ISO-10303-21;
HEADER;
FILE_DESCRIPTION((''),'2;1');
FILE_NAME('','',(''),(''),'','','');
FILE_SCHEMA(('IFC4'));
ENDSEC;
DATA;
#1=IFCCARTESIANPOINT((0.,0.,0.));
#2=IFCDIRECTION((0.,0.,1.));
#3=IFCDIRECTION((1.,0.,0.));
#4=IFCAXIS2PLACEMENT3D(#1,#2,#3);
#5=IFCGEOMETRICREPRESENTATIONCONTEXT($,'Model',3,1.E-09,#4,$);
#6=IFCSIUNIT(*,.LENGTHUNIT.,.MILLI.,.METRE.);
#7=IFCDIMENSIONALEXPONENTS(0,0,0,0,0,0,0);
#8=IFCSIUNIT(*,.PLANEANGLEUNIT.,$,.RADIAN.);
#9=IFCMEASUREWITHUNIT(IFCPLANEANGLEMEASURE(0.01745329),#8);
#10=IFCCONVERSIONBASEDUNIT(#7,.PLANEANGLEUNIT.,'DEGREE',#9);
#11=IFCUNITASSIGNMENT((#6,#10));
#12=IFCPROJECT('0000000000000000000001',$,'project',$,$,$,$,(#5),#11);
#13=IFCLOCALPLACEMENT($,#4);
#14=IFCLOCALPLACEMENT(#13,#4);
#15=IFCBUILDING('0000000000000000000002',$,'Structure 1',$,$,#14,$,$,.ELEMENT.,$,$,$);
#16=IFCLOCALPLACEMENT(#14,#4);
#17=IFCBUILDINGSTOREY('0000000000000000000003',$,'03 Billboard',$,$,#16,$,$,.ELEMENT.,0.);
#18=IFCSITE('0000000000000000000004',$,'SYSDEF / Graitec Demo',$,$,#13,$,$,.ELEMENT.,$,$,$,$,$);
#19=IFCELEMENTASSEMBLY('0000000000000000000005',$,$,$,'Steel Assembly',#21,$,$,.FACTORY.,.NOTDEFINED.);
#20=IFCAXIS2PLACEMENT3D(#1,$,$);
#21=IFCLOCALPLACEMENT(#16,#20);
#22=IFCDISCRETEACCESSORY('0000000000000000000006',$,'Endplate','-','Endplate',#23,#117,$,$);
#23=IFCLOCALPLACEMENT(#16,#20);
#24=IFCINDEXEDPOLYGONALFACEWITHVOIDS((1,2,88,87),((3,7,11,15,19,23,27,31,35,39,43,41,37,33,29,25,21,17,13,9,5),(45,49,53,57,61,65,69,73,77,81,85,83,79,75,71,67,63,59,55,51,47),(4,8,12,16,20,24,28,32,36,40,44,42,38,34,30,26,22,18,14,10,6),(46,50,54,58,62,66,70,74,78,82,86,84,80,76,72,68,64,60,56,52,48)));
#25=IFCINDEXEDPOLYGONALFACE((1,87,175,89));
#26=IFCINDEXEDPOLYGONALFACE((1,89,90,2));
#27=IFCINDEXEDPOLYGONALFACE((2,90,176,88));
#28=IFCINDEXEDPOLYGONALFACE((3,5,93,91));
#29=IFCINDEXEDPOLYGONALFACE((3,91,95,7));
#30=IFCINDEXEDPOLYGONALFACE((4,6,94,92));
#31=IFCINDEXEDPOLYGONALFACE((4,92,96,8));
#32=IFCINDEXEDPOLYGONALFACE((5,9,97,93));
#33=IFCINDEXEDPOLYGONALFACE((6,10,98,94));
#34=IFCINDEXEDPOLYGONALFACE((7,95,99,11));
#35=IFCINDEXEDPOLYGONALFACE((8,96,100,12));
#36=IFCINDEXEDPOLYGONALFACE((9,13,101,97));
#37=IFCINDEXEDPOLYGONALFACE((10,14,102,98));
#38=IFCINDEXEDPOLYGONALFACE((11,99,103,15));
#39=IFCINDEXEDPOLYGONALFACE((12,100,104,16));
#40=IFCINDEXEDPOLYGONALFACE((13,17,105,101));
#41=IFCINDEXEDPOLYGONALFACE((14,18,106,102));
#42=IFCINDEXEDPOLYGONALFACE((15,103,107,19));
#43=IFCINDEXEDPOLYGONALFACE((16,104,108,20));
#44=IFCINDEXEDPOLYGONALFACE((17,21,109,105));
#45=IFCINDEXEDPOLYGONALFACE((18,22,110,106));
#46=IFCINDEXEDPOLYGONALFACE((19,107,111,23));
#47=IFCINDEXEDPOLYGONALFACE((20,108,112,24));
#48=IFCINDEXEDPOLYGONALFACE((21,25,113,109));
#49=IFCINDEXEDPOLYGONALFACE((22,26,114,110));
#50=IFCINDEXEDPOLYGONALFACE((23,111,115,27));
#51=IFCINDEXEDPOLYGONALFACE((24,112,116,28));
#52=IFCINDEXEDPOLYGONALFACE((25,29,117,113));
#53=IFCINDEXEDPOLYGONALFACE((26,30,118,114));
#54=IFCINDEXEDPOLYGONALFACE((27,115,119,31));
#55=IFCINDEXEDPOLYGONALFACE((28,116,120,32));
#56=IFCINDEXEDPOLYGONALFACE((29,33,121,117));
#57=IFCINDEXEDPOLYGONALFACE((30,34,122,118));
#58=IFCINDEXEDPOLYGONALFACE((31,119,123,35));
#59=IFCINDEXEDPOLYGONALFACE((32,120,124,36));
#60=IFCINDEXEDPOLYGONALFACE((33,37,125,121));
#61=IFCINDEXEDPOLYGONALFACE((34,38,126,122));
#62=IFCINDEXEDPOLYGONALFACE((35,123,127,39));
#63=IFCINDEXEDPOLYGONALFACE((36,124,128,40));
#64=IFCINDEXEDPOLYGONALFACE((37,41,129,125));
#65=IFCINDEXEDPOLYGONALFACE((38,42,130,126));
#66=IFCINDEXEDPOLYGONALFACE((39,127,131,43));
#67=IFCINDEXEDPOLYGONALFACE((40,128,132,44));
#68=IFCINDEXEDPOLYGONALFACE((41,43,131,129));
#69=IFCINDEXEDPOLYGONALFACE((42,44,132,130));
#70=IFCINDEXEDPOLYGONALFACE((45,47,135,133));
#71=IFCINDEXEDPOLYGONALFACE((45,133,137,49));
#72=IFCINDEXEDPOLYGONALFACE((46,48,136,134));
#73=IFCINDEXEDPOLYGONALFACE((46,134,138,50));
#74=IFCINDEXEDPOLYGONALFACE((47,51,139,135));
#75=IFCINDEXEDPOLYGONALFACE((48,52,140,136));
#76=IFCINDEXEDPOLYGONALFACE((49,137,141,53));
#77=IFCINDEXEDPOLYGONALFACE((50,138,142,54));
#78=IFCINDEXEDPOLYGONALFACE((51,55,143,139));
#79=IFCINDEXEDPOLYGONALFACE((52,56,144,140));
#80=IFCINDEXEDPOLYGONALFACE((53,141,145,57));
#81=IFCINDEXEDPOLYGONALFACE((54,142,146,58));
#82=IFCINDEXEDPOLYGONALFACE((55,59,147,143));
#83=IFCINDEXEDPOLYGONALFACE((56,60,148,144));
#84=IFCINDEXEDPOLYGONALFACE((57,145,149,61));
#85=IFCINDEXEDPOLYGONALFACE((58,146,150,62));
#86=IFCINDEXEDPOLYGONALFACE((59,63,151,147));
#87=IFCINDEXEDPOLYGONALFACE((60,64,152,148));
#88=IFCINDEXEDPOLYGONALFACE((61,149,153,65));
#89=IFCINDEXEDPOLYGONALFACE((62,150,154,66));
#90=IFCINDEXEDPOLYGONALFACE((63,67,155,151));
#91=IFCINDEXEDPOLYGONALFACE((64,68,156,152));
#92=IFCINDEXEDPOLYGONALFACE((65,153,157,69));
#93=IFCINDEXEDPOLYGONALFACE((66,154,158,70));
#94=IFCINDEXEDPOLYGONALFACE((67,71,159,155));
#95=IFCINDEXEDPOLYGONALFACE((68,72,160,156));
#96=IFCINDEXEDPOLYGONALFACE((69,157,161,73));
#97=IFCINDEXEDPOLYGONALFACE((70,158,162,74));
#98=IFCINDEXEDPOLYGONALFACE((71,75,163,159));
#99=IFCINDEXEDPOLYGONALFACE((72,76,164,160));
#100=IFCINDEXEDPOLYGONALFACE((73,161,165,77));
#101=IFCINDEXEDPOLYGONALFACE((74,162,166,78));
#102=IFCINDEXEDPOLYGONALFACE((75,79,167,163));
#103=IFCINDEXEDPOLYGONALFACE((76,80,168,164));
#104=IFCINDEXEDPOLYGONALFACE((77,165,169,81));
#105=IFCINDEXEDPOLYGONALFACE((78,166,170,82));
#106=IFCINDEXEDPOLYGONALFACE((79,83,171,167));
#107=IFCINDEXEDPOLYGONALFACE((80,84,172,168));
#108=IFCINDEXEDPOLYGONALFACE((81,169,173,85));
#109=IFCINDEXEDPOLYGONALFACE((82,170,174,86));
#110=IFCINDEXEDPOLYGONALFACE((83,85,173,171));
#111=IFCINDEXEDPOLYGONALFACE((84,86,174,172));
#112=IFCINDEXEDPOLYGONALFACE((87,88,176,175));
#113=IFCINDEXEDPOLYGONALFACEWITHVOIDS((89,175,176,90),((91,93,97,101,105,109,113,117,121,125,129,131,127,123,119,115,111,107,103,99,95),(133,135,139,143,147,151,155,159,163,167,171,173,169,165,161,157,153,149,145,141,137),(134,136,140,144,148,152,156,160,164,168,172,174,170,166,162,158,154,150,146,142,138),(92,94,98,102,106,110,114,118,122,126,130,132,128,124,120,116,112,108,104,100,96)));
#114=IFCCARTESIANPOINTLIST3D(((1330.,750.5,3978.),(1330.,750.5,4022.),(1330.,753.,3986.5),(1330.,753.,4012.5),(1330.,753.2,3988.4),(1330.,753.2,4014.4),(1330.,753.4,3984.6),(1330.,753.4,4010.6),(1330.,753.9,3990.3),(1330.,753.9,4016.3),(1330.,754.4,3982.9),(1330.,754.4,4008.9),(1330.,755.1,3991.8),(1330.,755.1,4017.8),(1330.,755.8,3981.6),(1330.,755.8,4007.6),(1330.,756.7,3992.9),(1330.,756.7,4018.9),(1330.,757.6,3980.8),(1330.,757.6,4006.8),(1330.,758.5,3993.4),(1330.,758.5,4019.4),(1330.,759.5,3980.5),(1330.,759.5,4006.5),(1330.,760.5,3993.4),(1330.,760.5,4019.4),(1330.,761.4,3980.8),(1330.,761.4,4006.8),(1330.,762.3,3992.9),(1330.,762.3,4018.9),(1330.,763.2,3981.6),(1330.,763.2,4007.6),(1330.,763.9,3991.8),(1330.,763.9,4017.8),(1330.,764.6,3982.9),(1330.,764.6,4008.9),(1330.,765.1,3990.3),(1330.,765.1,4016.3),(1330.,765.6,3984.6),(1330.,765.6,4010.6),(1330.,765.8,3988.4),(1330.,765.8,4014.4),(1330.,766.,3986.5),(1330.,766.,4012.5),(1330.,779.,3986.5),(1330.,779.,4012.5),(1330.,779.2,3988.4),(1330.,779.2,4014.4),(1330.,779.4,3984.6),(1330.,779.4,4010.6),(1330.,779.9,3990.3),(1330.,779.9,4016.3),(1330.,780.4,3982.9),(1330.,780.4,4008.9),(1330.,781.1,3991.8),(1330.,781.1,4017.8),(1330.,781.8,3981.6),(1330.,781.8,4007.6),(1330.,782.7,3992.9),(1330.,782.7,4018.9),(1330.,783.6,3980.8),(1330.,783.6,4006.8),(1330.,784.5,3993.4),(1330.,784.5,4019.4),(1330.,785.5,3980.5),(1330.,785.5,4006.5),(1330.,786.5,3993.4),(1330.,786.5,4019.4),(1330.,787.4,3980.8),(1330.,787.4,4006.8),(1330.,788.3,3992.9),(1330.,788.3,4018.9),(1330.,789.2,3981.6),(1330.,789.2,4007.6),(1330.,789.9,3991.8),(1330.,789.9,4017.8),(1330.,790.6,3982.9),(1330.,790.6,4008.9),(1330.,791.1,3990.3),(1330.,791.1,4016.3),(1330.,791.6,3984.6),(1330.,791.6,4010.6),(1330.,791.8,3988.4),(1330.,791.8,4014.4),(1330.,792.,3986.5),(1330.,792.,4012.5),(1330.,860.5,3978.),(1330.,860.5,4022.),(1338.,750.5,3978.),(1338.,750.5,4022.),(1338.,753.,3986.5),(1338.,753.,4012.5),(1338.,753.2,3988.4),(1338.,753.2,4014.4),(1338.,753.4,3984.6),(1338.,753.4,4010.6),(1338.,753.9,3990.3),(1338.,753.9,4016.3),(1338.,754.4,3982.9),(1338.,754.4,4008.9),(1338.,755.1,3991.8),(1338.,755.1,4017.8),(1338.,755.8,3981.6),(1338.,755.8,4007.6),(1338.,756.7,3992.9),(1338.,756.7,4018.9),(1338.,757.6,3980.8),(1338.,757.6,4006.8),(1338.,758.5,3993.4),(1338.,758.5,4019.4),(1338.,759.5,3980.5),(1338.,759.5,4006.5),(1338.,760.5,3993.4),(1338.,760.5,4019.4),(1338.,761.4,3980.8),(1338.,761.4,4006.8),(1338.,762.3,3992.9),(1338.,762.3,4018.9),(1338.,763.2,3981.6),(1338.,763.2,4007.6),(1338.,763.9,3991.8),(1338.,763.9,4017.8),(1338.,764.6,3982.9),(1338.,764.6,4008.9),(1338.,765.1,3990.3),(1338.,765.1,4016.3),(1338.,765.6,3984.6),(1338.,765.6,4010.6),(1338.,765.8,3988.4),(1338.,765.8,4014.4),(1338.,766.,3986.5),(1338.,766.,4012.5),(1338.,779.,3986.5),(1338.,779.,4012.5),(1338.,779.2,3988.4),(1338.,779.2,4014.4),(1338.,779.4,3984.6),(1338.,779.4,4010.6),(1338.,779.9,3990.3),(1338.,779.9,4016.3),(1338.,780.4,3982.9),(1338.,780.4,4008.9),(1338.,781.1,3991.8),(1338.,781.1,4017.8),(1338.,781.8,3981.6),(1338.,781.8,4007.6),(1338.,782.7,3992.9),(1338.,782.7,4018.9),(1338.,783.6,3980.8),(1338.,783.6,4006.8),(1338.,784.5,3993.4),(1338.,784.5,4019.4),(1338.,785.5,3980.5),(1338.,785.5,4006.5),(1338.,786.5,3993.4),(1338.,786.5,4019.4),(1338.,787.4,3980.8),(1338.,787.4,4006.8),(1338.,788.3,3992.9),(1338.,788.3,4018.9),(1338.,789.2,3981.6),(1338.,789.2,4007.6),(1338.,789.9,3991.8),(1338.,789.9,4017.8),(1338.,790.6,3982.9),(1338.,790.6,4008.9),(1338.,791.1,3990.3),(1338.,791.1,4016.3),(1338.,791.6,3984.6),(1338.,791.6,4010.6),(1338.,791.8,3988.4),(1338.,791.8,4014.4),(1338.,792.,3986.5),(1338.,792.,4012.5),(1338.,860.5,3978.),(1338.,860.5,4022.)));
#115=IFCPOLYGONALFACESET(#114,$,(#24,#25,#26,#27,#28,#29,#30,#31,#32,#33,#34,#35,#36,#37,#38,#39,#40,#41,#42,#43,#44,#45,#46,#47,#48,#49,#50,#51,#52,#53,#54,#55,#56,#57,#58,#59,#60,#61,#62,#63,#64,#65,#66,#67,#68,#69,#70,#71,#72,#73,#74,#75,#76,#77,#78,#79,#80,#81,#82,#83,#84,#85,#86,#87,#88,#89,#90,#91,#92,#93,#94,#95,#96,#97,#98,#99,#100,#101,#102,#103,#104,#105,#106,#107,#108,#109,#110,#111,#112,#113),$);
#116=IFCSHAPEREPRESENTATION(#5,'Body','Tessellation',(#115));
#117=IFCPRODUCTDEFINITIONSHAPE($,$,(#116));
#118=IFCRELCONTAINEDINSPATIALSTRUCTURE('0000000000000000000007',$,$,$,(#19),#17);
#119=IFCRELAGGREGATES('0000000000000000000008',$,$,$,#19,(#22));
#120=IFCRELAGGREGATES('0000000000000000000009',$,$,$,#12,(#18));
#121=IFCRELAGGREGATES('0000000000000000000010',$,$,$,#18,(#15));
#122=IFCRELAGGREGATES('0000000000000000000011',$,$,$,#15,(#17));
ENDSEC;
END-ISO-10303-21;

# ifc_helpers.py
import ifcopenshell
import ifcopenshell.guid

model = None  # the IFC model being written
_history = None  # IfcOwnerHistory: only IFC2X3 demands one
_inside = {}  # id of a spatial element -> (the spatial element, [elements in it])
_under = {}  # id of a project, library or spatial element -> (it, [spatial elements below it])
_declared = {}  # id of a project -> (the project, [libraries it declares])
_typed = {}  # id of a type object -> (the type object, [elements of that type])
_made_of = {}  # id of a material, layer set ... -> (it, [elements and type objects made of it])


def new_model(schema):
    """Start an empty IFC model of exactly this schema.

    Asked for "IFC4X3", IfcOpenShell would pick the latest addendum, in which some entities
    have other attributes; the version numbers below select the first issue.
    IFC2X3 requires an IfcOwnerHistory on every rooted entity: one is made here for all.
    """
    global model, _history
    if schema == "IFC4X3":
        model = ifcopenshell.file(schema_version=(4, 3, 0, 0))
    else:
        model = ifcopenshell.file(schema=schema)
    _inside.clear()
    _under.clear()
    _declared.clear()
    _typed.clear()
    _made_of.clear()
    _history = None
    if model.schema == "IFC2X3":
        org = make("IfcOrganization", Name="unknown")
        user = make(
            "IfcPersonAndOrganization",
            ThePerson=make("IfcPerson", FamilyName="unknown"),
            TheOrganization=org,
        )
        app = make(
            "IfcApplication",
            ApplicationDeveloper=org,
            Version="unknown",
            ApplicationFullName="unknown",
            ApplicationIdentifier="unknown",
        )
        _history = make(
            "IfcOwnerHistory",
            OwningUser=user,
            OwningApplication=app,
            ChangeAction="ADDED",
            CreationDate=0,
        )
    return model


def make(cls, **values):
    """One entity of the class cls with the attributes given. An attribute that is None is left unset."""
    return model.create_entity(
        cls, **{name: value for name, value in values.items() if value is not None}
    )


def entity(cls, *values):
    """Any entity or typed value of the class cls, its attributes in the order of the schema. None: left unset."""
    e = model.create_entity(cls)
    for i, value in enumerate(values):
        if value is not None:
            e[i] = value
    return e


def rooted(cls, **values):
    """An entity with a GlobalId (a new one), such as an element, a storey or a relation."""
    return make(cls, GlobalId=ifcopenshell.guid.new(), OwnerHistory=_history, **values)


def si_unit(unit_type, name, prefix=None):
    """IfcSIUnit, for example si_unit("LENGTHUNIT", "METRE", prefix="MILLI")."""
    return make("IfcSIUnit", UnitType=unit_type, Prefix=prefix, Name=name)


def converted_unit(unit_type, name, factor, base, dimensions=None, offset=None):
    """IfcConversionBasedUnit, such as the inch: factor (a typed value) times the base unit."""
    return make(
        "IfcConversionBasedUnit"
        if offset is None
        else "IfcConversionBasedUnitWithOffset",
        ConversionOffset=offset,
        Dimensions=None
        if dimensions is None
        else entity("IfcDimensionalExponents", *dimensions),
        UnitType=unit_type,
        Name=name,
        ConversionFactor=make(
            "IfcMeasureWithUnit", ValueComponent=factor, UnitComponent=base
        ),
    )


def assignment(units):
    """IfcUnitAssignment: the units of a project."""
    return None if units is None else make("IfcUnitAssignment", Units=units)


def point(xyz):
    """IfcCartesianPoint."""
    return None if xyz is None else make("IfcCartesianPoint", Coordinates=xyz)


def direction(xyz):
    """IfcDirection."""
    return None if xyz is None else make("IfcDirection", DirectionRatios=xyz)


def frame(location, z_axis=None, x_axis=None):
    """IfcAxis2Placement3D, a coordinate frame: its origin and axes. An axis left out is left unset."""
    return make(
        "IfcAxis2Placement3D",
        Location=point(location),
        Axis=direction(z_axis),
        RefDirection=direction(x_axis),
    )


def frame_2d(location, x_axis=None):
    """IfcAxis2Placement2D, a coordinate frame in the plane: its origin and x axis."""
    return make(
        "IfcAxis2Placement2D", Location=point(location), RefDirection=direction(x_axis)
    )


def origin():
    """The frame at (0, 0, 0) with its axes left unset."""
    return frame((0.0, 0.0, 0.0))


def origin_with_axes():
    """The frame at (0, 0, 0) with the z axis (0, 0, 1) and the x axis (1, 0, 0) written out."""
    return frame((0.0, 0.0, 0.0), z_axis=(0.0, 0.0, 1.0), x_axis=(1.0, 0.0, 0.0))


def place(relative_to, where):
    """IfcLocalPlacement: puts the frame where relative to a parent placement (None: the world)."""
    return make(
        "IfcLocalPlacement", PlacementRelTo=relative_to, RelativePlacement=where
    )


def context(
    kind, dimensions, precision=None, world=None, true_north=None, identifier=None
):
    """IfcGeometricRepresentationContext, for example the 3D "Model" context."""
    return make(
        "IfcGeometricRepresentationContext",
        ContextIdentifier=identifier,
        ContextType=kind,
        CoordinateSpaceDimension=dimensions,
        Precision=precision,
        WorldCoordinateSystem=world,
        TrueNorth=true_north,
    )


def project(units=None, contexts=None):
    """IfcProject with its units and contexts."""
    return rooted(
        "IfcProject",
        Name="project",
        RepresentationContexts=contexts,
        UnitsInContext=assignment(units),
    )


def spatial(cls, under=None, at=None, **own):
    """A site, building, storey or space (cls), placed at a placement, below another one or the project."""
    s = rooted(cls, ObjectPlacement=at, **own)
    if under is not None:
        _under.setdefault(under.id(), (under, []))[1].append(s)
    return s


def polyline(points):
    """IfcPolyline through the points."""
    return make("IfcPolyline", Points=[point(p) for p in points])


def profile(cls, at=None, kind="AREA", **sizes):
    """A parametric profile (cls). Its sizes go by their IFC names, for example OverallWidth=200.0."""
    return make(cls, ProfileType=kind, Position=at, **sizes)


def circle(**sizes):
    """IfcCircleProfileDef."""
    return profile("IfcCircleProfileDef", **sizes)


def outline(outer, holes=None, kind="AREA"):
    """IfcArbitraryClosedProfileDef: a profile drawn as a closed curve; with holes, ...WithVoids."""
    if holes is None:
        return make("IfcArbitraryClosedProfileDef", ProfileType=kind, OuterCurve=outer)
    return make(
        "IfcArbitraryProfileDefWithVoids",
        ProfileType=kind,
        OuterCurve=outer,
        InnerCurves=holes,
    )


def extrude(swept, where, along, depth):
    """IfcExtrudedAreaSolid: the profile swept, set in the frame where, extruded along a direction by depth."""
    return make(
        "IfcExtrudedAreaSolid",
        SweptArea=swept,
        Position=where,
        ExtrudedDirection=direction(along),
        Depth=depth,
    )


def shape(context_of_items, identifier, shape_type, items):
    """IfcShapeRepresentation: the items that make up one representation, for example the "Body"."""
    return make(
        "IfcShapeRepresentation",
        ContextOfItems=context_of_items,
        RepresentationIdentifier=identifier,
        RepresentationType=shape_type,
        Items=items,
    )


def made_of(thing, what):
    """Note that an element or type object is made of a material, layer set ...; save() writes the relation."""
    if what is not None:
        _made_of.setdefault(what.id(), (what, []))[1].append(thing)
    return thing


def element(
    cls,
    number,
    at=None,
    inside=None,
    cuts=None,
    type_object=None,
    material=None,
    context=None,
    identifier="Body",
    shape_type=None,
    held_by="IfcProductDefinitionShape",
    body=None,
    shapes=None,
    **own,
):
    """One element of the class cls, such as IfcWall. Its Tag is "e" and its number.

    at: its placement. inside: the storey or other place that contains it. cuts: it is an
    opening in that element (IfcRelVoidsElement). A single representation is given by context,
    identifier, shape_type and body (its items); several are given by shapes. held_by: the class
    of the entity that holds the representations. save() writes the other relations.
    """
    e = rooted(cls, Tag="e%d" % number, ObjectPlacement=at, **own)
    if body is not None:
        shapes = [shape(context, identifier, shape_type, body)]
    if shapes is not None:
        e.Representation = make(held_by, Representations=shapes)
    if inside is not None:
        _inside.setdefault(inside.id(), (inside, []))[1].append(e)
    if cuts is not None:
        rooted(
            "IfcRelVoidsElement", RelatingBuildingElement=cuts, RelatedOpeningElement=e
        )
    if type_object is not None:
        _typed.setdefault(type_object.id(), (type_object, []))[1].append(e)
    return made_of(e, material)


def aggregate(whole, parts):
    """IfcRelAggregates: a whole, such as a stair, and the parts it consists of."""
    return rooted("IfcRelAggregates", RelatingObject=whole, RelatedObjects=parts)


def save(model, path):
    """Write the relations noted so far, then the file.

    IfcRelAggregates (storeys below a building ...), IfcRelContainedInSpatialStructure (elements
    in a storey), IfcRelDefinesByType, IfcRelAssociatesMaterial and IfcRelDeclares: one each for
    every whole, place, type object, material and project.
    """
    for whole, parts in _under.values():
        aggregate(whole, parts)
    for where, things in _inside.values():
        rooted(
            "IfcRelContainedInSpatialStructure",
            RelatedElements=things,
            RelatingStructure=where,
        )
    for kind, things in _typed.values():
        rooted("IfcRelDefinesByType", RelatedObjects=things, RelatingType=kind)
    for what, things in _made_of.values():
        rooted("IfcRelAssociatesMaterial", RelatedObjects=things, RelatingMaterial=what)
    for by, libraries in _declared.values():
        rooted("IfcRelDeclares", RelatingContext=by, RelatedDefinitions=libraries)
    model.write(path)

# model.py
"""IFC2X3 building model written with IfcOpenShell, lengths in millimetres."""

from ifc_helpers import new_model, entity, si_unit, converted_unit, frame, frame_2d, origin, origin_with_axes, place, context, project, spatial, polyline, circle, outline, extrude, element, aggregate, save


model = new_model("IFC2X3")

# Units and contexts
model_context = context("Model", 3, precision=1e-09, world=origin_with_axes())
ifc_project = project(units=[si_unit("LENGTHUNIT", "METRE", prefix="MILLI"), converted_unit("PLANEANGLEUNIT", "DEGREE", entity("IfcPlaneAngleMeasure", 0.01745329), si_unit("PLANEANGLEUNIT", "RADIAN"), dimensions=[0, 0, 0, 0, 0, 0, 0])], contexts=[model_context])

# Site, building, storey
site_placement = place(None, origin_with_axes())
site = spatial("IfcSite", under=ifc_project, at=site_placement, Name="SYSDEF / Graitec Demo", CompositionType="ELEMENT")
building_placement = place(site_placement, origin_with_axes())
building = spatial("IfcBuilding", under=site, at=building_placement, Name="Structure 1", CompositionType="ELEMENT")
storey_placement = place(building_placement, origin_with_axes())
storey = spatial("IfcBuildingStorey", under=building, at=storey_placement, Name="03 Billboard", CompositionType="ELEMENT", Elevation=0.0)

# Element assembly, discrete accessory, openings
assembly_1_placement = place(None, frame((935.5, 1441.4, 4091.5), z_axis=(-1.0, 0.0, 0.0), x_axis=(0.0, -1.0, 0.0)))
assembly_1 = element("IfcElementAssembly", 1, at=assembly_1_placement, inside=storey, ObjectType="Steel Assembly", AssemblyPlace="FACTORY", PredefinedType="NOTDEFINED")
discrete_accessory_1_placement = place(assembly_1_placement, frame((580.9, -69.5, -394.5), z_axis=(0.0, 0.0, -1.0), x_axis=(1.0, 0.0, 0.0)))
discrete_accessory_1 = element("IfcDiscreteAccessory", 2, at=discrete_accessory_1_placement, Name="Endplate", Description="-", ObjectType="Endplate", context=model_context, shape_type="SweptSolid", body=[
    extrude(outline(polyline([(0.0, 0.0), (110.0, 0.0), (110.0, 44.0), (0.0, 44.0), (0.0, 0.0)])), origin_with_axes(), (0.0, 0.0, 1.0), 8.0),
])
opening_1_placement = place(discrete_accessory_1_placement, frame((88.0, 22.0, -0.5), z_axis=(0.0, 0.0, 1.0), x_axis=(0.0, 1.0, 0.0)))
element("IfcOpeningElement", 3, at=opening_1_placement, cuts=discrete_accessory_1, ObjectType="Opening", context=model_context, shape_type="SweptSolid", body=[
    extrude(circle(Radius=6.5, at=frame_2d((13.0, 13.0), x_axis=(1.0, 0.0))), origin(), (0.0, 0.0, 1.0), 9.0),
])
opening_2_placement = place(discrete_accessory_1_placement, frame((88.0, 22.0, -0.5), z_axis=(0.0, 0.0, 1.0), x_axis=(0.0, 1.0, 0.0)))
element("IfcOpeningElement", 4, at=opening_2_placement, cuts=discrete_accessory_1, ObjectType="Opening", context=model_context, shape_type="SweptSolid", body=[
    extrude(circle(Radius=6.5, at=frame_2d((-13.0, 13.0), x_axis=(1.0, 0.0))), origin(), (0.0, 0.0, 1.0), 9.0),
])
opening_3_placement = place(discrete_accessory_1_placement, frame((88.0, 22.0, -0.5), z_axis=(0.0, 0.0, 1.0), x_axis=(0.0, 1.0, 0.0)))
element("IfcOpeningElement", 5, at=opening_3_placement, cuts=discrete_accessory_1, ObjectType="Opening", context=model_context, shape_type="SweptSolid", body=[
    extrude(circle(Radius=6.5, at=frame_2d((13.0, -13.0), x_axis=(1.0, 0.0))), origin(), (0.0, 0.0, 1.0), 9.0),
])
opening_4_placement = place(discrete_accessory_1_placement, frame((88.0, 22.0, -0.5), z_axis=(0.0, 0.0, 1.0), x_axis=(0.0, 1.0, 0.0)))
element("IfcOpeningElement", 6, at=opening_4_placement, cuts=discrete_accessory_1, ObjectType="Opening", context=model_context, shape_type="SweptSolid", body=[
    extrude(circle(Radius=6.5, at=frame_2d((-13.0, -13.0), x_axis=(1.0, 0.0))), origin(), (0.0, 0.0, 1.0), 9.0),
])
aggregate(assembly_1, [discrete_accessory_1])

save(model, "model.ifc")
